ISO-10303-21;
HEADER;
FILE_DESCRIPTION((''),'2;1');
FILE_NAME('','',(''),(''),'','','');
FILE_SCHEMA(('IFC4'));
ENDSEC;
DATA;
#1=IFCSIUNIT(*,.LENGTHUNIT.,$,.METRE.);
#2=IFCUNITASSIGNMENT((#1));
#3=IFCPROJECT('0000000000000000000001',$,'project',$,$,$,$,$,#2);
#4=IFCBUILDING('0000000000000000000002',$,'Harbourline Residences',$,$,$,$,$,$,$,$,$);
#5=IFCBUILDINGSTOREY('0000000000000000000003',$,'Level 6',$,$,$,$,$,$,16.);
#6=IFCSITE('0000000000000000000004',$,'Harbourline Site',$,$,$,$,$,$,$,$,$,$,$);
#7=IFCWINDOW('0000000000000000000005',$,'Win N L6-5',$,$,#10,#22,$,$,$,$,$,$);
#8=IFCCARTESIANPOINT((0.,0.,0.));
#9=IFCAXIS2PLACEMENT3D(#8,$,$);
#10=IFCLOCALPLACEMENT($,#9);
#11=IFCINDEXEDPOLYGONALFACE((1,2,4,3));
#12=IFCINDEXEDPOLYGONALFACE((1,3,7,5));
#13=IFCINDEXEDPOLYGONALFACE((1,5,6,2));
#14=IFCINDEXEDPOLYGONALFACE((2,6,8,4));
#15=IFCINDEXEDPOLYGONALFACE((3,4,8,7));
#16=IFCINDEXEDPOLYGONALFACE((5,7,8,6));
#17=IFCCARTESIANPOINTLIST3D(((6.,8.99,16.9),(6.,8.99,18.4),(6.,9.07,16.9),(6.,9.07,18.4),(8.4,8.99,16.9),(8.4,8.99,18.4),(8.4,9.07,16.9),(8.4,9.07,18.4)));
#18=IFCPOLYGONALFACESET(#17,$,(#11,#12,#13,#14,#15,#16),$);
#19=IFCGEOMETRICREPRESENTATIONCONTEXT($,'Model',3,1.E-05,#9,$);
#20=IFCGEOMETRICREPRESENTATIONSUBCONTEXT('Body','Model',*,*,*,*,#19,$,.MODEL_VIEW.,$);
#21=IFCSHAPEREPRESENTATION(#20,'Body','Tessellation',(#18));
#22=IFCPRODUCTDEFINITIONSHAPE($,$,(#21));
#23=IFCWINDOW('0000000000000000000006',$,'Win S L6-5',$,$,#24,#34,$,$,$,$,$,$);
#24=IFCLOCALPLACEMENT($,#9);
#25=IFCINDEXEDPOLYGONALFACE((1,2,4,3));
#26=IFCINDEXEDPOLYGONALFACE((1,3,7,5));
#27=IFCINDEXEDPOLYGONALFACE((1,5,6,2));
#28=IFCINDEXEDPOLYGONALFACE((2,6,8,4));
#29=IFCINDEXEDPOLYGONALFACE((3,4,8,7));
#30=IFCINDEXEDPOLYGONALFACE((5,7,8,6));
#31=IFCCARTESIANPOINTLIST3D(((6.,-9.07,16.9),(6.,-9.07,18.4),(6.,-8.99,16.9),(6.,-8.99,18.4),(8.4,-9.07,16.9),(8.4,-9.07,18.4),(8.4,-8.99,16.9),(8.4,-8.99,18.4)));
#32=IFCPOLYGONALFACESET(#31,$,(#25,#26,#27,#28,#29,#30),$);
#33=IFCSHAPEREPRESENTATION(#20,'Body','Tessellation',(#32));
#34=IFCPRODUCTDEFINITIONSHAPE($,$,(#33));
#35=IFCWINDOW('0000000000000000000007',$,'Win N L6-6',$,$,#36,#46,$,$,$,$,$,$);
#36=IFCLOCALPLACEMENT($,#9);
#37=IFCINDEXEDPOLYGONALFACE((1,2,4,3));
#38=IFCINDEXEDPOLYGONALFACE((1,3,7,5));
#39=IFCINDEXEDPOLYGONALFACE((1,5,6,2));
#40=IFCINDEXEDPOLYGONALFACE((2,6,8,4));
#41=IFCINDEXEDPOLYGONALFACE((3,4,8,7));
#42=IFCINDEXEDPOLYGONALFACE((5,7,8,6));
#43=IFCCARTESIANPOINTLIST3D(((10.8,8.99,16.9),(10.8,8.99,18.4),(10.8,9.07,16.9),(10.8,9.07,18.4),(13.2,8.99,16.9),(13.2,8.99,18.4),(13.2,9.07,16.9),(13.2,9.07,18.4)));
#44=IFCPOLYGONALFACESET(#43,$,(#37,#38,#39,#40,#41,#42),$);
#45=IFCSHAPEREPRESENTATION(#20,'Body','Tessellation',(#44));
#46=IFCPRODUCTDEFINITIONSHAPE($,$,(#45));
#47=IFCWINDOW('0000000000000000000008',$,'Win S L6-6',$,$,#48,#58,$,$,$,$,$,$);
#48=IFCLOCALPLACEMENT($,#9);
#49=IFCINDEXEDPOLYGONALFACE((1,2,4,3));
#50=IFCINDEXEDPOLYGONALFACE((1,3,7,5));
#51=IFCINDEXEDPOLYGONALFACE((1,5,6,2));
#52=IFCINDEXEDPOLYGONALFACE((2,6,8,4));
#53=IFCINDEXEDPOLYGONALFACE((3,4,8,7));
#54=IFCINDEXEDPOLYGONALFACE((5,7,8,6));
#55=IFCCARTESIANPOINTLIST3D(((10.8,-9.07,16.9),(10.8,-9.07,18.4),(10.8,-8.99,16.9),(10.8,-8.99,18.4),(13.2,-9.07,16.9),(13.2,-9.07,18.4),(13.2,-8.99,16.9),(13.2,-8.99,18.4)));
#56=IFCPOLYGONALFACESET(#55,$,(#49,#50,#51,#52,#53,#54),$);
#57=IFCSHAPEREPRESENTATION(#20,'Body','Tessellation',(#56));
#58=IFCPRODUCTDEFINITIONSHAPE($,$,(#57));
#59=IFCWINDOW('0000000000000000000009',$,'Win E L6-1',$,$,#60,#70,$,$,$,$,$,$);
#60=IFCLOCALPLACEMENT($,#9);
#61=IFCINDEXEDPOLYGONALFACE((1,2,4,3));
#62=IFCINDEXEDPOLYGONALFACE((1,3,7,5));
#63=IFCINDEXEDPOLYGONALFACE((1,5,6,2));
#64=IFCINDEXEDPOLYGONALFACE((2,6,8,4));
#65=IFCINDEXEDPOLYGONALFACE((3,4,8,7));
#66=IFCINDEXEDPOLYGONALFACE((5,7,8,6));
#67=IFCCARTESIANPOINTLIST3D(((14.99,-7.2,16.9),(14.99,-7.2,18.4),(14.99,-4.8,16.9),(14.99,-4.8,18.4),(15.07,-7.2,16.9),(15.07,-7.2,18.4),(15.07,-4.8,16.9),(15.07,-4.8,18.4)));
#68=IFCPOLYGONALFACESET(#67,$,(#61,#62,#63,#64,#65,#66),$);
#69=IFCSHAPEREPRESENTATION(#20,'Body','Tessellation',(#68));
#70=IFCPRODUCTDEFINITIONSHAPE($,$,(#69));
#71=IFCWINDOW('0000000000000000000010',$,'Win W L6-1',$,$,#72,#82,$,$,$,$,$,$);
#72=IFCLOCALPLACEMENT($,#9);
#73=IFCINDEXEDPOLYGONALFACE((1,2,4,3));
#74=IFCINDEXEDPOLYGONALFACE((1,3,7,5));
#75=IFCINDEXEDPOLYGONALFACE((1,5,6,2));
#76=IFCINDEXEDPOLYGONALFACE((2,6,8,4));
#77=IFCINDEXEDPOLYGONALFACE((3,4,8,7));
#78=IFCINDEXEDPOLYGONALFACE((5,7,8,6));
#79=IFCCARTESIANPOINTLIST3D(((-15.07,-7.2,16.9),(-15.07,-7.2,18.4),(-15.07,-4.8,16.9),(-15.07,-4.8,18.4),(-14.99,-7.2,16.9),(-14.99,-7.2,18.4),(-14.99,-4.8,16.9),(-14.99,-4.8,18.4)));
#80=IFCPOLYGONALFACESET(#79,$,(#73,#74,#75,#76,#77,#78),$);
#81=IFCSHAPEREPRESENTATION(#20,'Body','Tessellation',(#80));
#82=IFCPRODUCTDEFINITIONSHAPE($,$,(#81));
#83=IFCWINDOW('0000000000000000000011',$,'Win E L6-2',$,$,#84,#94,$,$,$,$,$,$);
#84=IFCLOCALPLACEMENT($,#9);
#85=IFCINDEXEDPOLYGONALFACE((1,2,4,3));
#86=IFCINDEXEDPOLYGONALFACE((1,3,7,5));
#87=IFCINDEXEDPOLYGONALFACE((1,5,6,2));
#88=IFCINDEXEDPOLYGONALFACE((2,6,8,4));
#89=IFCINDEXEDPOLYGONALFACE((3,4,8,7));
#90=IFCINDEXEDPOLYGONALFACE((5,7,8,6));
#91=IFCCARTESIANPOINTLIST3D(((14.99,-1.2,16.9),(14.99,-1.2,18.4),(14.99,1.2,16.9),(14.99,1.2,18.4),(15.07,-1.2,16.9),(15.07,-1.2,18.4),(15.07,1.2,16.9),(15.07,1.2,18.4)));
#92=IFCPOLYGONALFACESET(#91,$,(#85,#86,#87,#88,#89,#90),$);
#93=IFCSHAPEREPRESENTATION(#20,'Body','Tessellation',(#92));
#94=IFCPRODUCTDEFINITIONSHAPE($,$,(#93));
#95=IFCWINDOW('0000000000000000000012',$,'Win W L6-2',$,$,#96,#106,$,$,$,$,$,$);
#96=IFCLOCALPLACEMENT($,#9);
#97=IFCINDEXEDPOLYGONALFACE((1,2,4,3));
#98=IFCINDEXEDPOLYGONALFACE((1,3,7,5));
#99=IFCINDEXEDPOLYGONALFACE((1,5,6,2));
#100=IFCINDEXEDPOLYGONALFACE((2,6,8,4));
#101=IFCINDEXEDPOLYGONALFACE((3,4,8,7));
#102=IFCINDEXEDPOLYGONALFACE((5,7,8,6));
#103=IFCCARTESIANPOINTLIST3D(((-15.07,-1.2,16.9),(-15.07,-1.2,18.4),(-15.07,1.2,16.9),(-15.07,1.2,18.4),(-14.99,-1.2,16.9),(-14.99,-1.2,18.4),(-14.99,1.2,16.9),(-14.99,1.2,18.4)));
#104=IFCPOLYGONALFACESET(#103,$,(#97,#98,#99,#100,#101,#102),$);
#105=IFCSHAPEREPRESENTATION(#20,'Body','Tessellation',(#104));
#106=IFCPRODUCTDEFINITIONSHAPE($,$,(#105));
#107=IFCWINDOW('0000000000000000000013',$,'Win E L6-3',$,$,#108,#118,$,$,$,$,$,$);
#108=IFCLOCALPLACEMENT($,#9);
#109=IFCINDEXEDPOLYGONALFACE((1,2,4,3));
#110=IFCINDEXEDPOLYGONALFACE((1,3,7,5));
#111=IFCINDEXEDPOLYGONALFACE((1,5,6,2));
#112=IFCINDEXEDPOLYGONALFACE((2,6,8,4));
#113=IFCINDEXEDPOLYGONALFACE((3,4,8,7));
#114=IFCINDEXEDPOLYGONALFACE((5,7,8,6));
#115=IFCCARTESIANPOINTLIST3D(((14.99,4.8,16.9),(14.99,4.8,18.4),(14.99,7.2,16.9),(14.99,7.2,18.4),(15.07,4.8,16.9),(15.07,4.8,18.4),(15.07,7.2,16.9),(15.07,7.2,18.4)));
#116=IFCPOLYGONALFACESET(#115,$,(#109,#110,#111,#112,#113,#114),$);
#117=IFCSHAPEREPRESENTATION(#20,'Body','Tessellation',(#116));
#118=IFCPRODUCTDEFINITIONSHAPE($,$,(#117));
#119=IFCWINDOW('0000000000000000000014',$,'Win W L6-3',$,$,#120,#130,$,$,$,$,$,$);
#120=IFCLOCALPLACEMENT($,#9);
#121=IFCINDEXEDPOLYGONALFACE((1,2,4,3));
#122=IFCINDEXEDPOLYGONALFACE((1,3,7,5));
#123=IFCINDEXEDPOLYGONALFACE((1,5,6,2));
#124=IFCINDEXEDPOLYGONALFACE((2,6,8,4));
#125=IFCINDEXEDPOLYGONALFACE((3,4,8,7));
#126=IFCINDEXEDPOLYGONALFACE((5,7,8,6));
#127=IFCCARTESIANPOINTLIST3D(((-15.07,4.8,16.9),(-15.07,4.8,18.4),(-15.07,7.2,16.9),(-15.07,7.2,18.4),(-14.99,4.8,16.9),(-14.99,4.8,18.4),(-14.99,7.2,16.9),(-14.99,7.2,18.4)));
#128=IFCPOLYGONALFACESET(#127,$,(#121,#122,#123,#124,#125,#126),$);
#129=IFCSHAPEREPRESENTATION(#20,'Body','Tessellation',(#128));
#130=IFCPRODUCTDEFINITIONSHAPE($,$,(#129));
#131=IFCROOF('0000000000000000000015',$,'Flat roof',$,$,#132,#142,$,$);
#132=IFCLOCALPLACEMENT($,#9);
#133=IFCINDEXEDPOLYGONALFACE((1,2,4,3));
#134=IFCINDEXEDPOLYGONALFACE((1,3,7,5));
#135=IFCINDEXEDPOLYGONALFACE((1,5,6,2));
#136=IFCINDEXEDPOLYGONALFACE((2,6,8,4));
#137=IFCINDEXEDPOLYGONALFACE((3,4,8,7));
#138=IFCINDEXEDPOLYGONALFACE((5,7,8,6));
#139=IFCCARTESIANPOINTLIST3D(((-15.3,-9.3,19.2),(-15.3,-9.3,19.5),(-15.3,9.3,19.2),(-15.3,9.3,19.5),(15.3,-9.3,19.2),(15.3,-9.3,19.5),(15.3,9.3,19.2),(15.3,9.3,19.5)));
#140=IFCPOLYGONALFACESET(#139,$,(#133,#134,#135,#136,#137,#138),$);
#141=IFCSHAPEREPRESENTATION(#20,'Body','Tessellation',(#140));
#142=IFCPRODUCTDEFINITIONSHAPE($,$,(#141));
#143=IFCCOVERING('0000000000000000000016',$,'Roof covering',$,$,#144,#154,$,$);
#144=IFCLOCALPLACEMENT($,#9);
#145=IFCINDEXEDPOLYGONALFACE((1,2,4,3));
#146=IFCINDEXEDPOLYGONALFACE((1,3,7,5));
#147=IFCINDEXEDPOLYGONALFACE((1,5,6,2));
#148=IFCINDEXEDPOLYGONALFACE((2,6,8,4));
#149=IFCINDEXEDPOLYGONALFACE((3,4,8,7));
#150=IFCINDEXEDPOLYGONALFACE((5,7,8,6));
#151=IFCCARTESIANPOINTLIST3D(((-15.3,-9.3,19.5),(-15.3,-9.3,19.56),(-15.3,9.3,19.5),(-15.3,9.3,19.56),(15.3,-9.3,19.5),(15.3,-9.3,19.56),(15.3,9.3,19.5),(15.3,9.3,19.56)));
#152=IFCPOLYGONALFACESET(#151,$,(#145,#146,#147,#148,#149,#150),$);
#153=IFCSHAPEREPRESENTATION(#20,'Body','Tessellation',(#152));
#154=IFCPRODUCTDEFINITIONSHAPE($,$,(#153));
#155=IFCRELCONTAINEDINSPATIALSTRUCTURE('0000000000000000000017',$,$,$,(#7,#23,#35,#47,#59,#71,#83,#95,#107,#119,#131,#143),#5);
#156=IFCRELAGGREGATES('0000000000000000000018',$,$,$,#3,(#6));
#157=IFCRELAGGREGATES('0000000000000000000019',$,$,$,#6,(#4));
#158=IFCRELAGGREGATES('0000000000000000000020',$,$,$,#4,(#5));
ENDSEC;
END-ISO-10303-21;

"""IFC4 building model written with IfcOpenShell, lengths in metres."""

from ifc_helpers import new_model, si_unit, frame, frame_2d, origin, origin_2d, context, subcontext, project, spatial, rectangle, extrude, element, save


model = new_model("IFC4")

# Units and contexts
model_context = context("Model", 3, precision=1e-05, world=origin())
body_context = subcontext(model_context, "Body", "Model", "MODEL_VIEW")
ifc_project = project(units=[si_unit("LENGTHUNIT", "METRE")])

# Site, building, storey
site = spatial("IfcSite", under=ifc_project, Name="Harbourline Site")
building = spatial("IfcBuilding", under=site, Name="Harbourline Residences")
storey = spatial("IfcBuildingStorey", under=building, Name="Level 6", Elevation=16.0)

# Windows
element("IfcWindow", 1, inside=storey, Name="Win N L6-5", context=body_context, shape_type="SweptSolid", body=[
    extrude(rectangle(XDim=2.4, YDim=0.08, at=frame_2d((7.2, 9.03))), frame((0.0, 0.0, 16.9)), (0.0, 0.0, 1.0), 1.5),
])
element("IfcWindow", 2, inside=storey, Name="Win S L6-5", context=body_context, shape_type="SweptSolid", body=[
    extrude(rectangle(XDim=2.4, YDim=0.08, at=frame_2d((7.2, -9.03))), frame((0.0, 0.0, 16.9)), (0.0, 0.0, 1.0), 1.5),
])
element("IfcWindow", 3, inside=storey, Name="Win N L6-6", context=body_context, shape_type="SweptSolid", body=[
    extrude(rectangle(XDim=2.4, YDim=0.08, at=frame_2d((12.0, 9.03))), frame((0.0, 0.0, 16.9)), (0.0, 0.0, 1.0), 1.5),
])
element("IfcWindow", 4, inside=storey, Name="Win S L6-6", context=body_context, shape_type="SweptSolid", body=[
    extrude(rectangle(XDim=2.4, YDim=0.08, at=frame_2d((12.0, -9.03))), frame((0.0, 0.0, 16.9)), (0.0, 0.0, 1.0), 1.5),
])
element("IfcWindow", 5, inside=storey, Name="Win E L6-1", context=body_context, shape_type="SweptSolid", body=[
    extrude(rectangle(XDim=0.08, YDim=2.4, at=frame_2d((15.03, -6.0))), frame((0.0, 0.0, 16.9)), (0.0, 0.0, 1.0), 1.5),
])
element("IfcWindow", 6, inside=storey, Name="Win W L6-1", context=body_context, shape_type="SweptSolid", body=[
    extrude(rectangle(XDim=0.08, YDim=2.4, at=frame_2d((-15.03, -6.0))), frame((0.0, 0.0, 16.9)), (0.0, 0.0, 1.0), 1.5),
])
element("IfcWindow", 7, inside=storey, Name="Win E L6-2", context=body_context, shape_type="SweptSolid", body=[
    extrude(rectangle(XDim=0.08, YDim=2.4, at=frame_2d((15.03, 0.0))), frame((0.0, 0.0, 16.9)), (0.0, 0.0, 1.0), 1.5),
])
element("IfcWindow", 8, inside=storey, Name="Win W L6-2", context=body_context, shape_type="SweptSolid", body=[
    extrude(rectangle(XDim=0.08, YDim=2.4, at=frame_2d((-15.03, 0.0))), frame((0.0, 0.0, 16.9)), (0.0, 0.0, 1.0), 1.5),
])
element("IfcWindow", 9, inside=storey, Name="Win E L6-3", context=body_context, shape_type="SweptSolid", body=[
    extrude(rectangle(XDim=0.08, YDim=2.4, at=frame_2d((15.03, 6.0))), frame((0.0, 0.0, 16.9)), (0.0, 0.0, 1.0), 1.5),
])
element("IfcWindow", 10, inside=storey, Name="Win W L6-3", context=body_context, shape_type="SweptSolid", body=[
    extrude(rectangle(XDim=0.08, YDim=2.4, at=frame_2d((-15.03, 6.0))), frame((0.0, 0.0, 16.9)), (0.0, 0.0, 1.0), 1.5),
])

# Roof
element("IfcRoof", 11, inside=storey, Name="Flat roof", context=body_context, shape_type="SweptSolid", body=[
    extrude(rectangle(XDim=30.6, YDim=18.6, at=origin_2d()), frame((0.0, 0.0, 19.2)), (0.0, 0.0, 1.0), 0.3),
])

# Covering
element("IfcCovering", 12, inside=storey, Name="Roof covering", context=body_context, shape_type="SweptSolid", body=[
    extrude(rectangle(XDim=30.6, YDim=18.6, at=origin_2d()), frame((0.0, 0.0, 19.5)), (0.0, 0.0, 1.0), 0.06),
])

save(model, "model.ifc")
